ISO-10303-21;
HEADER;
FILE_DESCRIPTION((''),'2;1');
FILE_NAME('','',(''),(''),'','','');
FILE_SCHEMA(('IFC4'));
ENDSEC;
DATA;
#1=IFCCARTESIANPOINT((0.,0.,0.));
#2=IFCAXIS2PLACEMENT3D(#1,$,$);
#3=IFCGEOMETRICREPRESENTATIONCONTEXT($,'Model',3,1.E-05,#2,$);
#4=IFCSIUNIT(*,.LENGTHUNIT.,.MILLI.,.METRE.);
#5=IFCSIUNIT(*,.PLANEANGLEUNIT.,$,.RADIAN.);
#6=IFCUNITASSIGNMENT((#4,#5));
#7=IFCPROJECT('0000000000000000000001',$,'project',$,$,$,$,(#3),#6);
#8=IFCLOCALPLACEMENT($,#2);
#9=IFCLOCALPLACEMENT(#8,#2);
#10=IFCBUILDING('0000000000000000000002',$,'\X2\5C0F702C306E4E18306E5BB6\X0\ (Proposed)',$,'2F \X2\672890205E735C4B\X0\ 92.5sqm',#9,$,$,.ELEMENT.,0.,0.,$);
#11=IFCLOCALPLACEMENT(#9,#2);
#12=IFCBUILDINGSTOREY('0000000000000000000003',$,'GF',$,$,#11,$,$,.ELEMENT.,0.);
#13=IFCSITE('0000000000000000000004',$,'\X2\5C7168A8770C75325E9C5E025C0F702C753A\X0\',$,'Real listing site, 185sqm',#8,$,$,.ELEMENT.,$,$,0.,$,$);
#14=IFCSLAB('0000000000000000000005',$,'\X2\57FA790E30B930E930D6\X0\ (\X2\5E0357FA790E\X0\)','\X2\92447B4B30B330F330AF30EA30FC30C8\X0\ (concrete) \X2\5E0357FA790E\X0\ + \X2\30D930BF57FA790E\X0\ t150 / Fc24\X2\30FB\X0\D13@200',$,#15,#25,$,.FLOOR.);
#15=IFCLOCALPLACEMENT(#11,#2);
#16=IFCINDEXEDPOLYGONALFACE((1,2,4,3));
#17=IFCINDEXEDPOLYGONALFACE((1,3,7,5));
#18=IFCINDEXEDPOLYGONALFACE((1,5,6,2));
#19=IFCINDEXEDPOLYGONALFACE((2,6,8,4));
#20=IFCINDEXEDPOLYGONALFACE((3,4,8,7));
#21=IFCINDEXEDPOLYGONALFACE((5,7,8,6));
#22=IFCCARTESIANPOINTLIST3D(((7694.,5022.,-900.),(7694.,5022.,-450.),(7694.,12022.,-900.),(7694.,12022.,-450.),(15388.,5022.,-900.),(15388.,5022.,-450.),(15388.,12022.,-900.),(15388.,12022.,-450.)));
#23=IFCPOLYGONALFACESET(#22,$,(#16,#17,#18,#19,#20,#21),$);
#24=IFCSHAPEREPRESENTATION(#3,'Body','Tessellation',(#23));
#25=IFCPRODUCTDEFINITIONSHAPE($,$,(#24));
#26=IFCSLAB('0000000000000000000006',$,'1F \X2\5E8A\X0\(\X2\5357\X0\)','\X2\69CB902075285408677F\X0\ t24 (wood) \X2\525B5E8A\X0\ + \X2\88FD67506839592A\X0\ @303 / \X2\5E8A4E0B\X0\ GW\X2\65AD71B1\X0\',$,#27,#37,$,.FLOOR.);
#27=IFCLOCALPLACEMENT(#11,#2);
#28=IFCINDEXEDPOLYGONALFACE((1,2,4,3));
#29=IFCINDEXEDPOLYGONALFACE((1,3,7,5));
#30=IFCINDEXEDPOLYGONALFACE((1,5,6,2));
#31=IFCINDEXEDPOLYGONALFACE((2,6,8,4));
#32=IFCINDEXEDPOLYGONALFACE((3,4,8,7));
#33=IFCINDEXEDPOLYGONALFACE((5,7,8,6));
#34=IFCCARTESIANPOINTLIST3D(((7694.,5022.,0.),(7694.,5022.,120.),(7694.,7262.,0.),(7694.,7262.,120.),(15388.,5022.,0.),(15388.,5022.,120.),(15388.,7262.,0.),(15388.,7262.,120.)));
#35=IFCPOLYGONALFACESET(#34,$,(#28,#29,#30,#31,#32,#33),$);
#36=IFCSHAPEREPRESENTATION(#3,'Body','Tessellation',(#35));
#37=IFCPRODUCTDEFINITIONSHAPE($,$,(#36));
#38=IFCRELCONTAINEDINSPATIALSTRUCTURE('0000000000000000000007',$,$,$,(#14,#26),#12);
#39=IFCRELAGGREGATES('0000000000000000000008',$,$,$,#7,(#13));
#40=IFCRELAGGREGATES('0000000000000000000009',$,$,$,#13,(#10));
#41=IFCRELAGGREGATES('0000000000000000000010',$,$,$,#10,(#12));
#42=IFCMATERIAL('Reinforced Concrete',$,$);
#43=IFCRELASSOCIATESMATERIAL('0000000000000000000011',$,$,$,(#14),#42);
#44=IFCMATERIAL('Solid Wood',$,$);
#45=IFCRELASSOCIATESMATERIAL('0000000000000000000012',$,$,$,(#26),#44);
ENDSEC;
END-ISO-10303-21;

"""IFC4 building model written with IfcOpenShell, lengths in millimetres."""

from ifc_helpers import new_model, si_unit, frame, frame_2d, origin, place, context, project, spatial, rectangle, extrude, material, element, save


model = new_model("IFC4")

# Units and contexts
model_context = context("Model", 3, precision=1e-05, world=origin())
ifc_project = project(units=[si_unit("LENGTHUNIT", "METRE", prefix="MILLI"), si_unit("PLANEANGLEUNIT", "RADIAN")], contexts=[model_context])

# Site, building, storey
site_placement = place(None, origin())
site = spatial("IfcSite", under=ifc_project, at=site_placement, Name="山梨県甲府市小瀬町", ObjectType="Real listing site, 185sqm", CompositionType="ELEMENT", RefElevation=0.0)
building_placement = place(site_placement, origin())
building = spatial("IfcBuilding", under=site, at=building_placement, Name="小瀬の丘の家 (Proposed)", ObjectType="2F 木造平屋 92.5sqm", CompositionType="ELEMENT", ElevationOfRefHeight=0.0, ElevationOfTerrain=0.0)
storey_placement = place(building_placement, origin())
storey = spatial("IfcBuildingStorey", under=building, at=storey_placement, Name="GF", CompositionType="ELEMENT", Elevation=0.0)

# Slabs
ifc_material_1 = material(Name="Reinforced Concrete")
slab_1_placement = place(storey_placement, frame((3847.0, 2511.0, -450.0)))
element("IfcSlab", 1, at=slab_1_placement, inside=storey, material=ifc_material_1, Name="基礎スラブ (布基礎)", Description="鉄筋コンクリート (concrete) 布基礎 + ベタ基礎 t150 / Fc24・D13@200", PredefinedType="FLOOR", context=model_context, shape_type="SweptSolid", body=[
    extrude(rectangle(XDim=7694.0, YDim=7000.0, at=frame_2d((3847.0, 3500.0))), frame((3847.0, 2511.0, -450.0)), (0.0, 0.0, 1.0), 450.0),
])
ifc_material_2 = material(Name="Solid Wood")
slab_2_placement = place(storey_placement, frame((3847.0, 2511.0, 0.0)))
element("IfcSlab", 2, at=slab_2_placement, inside=storey, material=ifc_material_2, Name="1F 床(南)", Description="構造用合板 t24 (wood) 剛床 + 製材根太 @303 / 床下 GW断熱", PredefinedType="FLOOR", context=model_context, shape_type="SweptSolid", body=[
    extrude(rectangle(XDim=7694.0, YDim=2240.0, at=frame_2d((3847.0, 1120.0))), frame((3847.0, 2511.0, 0.0)), (0.0, 0.0, 1.0), 120.0),
])

save(model, "model.ifc")
